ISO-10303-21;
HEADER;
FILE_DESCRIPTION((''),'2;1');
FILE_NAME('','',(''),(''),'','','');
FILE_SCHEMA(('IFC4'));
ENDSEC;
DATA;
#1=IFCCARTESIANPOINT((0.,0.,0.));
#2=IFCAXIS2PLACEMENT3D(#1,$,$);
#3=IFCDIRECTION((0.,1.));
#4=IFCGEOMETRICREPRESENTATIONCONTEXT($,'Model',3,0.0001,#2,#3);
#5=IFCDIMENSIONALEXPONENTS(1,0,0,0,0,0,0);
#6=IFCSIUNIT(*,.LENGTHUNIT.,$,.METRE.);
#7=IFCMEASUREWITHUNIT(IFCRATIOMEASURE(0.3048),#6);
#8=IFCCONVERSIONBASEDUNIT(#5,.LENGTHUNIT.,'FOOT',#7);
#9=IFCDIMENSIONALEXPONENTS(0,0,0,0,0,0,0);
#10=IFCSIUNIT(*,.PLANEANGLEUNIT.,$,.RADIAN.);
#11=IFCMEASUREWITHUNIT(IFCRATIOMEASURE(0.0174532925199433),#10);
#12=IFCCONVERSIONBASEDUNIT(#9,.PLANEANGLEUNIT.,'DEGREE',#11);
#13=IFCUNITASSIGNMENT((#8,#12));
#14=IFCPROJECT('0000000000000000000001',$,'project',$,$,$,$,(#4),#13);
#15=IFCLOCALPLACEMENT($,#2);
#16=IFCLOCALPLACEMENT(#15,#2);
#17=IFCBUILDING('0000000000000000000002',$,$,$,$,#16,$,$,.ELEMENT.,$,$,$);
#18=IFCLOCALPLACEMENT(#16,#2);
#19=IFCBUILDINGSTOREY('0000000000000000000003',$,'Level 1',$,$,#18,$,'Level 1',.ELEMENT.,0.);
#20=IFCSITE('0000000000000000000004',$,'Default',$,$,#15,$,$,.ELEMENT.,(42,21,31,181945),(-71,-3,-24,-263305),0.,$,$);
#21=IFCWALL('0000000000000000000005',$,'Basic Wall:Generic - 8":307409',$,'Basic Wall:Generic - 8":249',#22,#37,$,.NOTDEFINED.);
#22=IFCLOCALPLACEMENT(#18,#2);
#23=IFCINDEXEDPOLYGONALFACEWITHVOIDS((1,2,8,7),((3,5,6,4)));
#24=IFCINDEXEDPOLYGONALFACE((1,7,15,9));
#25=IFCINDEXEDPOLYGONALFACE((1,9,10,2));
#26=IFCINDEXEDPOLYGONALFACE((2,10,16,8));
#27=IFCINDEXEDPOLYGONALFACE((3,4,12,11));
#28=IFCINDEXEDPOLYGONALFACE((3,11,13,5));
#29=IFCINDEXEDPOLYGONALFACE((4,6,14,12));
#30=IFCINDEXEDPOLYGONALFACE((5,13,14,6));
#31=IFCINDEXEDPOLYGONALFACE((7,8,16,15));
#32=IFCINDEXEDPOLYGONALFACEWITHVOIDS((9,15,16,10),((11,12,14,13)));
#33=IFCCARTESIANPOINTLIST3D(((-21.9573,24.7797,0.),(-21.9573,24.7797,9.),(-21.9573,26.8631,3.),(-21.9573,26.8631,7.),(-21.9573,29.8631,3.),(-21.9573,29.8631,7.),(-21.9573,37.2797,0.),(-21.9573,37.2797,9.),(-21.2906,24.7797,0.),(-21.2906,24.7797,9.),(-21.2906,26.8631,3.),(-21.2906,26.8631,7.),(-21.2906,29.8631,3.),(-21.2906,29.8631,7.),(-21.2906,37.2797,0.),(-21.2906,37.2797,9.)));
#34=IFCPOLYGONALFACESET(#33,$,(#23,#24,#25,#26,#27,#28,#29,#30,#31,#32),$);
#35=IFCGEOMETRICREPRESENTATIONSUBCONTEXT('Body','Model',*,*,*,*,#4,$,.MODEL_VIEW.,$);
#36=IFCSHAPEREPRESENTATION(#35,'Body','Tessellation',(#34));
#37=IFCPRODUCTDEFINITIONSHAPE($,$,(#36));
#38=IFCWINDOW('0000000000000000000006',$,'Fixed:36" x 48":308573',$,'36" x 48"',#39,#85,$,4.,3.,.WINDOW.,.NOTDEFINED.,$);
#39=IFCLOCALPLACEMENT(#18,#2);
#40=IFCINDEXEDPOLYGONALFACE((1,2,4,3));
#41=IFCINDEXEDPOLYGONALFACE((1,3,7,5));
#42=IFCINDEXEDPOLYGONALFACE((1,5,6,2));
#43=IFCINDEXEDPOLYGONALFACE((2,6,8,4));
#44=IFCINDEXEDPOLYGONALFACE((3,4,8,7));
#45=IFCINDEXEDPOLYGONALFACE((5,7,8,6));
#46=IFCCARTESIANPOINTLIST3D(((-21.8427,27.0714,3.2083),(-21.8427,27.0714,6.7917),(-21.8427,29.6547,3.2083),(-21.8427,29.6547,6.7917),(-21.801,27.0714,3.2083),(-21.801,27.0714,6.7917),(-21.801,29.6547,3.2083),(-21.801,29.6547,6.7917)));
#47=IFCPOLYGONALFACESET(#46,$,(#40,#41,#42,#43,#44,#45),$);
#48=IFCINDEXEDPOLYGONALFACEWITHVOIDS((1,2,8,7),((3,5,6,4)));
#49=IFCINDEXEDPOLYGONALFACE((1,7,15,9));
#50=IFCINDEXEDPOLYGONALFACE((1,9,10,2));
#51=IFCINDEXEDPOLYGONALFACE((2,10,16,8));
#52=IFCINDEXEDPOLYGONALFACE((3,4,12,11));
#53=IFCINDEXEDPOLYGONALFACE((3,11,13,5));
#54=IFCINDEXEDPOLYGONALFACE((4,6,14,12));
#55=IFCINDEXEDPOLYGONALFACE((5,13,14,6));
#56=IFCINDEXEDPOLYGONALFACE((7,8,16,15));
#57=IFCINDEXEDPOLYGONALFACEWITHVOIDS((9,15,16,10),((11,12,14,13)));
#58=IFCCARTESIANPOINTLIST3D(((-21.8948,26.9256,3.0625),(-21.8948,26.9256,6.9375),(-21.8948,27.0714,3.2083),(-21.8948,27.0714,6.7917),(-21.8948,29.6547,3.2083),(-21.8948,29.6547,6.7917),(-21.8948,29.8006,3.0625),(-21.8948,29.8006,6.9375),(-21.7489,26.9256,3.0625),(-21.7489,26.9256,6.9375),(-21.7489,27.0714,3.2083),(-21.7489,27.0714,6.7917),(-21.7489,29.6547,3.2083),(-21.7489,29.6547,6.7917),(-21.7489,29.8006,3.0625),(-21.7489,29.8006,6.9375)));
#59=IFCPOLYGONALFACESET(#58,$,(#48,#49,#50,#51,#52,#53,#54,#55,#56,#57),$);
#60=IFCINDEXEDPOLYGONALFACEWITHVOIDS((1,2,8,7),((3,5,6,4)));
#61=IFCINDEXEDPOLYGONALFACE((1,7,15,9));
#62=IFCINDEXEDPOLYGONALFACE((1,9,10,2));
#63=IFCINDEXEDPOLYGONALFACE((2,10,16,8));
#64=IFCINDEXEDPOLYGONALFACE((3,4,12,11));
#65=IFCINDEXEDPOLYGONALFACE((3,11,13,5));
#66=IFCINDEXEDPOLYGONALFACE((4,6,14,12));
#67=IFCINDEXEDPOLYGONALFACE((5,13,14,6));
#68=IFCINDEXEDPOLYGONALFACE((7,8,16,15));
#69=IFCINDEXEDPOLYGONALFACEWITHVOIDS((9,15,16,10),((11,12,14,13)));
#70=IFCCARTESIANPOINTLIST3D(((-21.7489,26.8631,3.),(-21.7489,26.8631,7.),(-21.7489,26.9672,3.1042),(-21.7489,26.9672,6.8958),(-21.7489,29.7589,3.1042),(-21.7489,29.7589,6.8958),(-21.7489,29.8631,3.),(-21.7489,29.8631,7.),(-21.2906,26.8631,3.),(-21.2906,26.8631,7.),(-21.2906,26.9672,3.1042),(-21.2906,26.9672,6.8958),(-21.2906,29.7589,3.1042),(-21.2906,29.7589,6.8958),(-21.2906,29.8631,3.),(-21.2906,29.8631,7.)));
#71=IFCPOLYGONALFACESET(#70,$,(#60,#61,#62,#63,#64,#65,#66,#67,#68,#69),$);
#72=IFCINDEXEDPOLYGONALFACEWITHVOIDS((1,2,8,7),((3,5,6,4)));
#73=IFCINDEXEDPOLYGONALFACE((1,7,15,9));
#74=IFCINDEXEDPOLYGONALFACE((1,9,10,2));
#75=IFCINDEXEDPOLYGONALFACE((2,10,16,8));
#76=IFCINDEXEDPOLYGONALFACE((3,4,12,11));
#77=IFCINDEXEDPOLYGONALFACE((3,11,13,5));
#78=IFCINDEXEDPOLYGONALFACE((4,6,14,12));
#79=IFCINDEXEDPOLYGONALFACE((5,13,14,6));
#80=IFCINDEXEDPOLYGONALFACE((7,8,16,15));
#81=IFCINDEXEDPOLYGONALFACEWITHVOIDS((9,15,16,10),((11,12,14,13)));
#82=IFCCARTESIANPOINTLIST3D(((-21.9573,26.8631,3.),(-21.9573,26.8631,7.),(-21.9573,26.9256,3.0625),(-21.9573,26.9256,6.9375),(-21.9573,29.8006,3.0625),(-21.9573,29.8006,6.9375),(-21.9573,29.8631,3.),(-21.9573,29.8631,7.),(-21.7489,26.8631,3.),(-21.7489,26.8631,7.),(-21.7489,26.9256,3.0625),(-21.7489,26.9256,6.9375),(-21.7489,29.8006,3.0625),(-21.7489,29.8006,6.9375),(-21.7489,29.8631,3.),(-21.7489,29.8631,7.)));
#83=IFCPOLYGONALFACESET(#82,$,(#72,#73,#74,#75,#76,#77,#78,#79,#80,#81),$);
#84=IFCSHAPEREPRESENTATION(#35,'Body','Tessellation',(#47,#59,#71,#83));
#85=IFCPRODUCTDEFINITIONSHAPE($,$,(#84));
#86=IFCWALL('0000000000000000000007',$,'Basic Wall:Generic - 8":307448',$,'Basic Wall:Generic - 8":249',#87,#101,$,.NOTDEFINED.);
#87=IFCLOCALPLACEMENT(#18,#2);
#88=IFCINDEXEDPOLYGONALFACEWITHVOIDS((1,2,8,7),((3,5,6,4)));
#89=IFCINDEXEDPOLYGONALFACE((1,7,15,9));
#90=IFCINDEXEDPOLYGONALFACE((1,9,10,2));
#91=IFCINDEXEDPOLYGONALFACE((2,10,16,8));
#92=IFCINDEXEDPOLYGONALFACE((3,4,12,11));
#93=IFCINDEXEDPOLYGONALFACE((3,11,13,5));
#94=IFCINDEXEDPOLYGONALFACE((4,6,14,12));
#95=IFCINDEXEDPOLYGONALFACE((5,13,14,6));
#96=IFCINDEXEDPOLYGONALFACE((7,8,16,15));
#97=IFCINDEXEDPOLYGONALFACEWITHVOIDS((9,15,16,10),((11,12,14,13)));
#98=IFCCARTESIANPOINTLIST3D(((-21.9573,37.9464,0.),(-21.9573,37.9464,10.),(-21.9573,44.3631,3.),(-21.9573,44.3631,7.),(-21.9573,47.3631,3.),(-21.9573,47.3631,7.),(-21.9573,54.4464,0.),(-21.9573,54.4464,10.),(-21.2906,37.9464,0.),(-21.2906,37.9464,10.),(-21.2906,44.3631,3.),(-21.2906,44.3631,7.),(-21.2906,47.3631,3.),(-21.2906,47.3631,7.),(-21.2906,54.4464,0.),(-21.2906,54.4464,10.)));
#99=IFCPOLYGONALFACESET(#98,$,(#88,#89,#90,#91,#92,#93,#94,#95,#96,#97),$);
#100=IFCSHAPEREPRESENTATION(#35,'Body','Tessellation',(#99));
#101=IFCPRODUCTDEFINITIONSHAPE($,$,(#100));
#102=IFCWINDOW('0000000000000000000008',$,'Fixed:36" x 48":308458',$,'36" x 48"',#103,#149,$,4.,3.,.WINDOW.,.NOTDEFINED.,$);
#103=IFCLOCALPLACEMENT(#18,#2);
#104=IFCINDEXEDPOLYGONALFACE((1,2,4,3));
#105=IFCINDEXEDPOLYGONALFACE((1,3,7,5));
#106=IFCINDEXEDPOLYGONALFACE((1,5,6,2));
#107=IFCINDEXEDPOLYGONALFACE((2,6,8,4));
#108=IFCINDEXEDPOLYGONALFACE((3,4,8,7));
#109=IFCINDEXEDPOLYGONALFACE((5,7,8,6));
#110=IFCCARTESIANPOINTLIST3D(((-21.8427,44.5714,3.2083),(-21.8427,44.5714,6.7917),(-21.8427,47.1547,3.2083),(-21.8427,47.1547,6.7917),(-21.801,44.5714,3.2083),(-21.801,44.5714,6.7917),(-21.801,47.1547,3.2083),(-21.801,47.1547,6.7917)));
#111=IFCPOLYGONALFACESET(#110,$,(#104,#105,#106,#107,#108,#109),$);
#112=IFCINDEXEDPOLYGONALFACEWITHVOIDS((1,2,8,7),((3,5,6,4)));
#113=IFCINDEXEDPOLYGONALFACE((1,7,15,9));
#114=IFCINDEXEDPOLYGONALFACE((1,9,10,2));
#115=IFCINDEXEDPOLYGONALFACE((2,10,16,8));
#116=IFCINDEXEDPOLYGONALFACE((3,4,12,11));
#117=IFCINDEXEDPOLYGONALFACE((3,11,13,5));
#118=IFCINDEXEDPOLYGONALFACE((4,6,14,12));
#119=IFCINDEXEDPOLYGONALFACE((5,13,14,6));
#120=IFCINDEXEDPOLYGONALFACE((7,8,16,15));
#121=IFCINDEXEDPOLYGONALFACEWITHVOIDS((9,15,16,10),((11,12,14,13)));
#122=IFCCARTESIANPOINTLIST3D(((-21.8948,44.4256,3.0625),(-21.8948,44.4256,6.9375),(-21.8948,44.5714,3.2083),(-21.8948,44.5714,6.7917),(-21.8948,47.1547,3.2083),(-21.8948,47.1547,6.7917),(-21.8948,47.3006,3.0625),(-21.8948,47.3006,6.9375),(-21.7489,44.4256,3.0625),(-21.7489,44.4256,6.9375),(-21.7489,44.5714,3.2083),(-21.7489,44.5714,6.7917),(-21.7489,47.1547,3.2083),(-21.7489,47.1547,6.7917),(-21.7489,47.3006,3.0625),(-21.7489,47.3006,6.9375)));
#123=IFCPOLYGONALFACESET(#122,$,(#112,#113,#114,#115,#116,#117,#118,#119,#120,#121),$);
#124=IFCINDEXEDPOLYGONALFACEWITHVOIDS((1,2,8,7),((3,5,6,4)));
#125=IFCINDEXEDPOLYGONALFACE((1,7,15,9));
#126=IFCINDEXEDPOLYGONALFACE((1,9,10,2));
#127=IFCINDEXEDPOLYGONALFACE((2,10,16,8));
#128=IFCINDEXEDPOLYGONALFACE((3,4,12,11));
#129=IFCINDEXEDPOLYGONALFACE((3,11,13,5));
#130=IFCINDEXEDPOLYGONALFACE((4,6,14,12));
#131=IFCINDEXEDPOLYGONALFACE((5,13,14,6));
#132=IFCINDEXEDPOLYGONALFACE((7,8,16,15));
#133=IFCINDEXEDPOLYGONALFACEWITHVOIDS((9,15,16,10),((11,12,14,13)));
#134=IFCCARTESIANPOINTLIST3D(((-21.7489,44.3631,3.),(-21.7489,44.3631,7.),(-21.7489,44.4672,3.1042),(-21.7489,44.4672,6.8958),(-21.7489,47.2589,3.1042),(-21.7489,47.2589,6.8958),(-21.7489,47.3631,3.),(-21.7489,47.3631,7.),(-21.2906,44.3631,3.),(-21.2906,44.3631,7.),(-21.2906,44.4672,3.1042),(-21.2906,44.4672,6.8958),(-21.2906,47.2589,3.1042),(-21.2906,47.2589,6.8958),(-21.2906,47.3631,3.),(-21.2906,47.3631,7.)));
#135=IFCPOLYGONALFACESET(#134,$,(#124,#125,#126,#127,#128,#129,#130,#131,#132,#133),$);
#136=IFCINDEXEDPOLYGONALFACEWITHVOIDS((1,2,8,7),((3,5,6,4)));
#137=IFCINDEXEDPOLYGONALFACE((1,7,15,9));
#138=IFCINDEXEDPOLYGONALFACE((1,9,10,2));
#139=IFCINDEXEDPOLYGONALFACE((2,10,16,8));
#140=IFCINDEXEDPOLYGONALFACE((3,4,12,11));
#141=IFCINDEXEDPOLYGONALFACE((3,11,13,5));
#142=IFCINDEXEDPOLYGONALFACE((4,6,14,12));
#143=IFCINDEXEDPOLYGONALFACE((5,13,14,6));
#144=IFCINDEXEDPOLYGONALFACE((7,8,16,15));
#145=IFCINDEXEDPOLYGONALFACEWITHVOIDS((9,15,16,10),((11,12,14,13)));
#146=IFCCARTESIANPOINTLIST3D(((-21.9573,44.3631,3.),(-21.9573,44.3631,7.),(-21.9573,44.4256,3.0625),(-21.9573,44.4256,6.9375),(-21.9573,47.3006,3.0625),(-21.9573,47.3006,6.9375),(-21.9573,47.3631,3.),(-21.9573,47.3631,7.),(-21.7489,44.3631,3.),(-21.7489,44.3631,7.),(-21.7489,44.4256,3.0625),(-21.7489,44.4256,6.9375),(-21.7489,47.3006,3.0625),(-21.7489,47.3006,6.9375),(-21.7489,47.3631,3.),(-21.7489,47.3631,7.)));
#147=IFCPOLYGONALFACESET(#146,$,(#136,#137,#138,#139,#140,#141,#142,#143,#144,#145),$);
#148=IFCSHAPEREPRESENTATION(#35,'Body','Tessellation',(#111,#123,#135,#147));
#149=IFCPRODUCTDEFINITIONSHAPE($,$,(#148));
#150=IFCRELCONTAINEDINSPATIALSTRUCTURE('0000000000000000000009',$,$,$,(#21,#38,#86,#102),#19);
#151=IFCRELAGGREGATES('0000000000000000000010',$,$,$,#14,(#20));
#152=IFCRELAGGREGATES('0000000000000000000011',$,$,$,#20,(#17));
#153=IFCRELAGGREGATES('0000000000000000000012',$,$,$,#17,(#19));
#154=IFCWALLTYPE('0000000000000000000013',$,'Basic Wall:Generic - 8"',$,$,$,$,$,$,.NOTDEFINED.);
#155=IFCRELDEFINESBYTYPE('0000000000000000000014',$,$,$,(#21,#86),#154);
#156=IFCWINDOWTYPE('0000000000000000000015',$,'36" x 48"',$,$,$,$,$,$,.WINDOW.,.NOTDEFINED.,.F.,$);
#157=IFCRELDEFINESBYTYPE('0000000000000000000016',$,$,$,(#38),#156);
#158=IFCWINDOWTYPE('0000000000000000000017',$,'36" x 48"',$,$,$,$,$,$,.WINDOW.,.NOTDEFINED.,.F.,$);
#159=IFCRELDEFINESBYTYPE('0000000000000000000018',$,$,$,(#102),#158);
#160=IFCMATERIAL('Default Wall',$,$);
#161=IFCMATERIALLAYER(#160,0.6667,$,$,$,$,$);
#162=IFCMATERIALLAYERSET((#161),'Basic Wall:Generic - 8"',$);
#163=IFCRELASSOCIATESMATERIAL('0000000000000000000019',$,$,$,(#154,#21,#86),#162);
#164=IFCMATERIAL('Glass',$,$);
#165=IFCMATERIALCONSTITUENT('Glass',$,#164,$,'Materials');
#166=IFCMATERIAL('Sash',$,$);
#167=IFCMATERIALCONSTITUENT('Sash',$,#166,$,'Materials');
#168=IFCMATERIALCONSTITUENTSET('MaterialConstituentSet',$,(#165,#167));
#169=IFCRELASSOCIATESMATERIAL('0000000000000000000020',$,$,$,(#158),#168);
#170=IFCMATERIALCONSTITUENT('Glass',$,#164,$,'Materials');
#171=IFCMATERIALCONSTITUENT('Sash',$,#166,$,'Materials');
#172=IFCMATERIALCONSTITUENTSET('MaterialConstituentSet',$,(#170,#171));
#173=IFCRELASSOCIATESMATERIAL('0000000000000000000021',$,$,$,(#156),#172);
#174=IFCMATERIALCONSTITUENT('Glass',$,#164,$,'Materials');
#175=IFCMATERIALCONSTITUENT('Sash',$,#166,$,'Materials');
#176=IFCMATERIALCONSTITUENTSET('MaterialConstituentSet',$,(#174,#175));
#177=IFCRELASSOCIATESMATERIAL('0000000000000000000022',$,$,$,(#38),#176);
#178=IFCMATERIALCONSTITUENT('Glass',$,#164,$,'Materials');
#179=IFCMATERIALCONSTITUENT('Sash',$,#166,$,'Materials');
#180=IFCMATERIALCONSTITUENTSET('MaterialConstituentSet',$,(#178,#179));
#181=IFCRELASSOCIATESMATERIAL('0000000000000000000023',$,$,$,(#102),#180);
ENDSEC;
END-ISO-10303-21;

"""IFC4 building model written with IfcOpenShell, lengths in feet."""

from ifc_helpers import new_model, entity, si_unit, converted_unit, direction, frame, frame_2d, origin, place, context, subcontext, project, spatial, polyline, rectangle, outline, extrude, clip, bounded_halfspace, source, transform, mapped, material, layer, layer_set, layer_usage, constituent, constituent_set, type_object, type_shapes, element, fill, save


model = new_model("IFC4")

# Units and contexts
model_context = context("Model", 3, precision=0.0001, world=origin(), true_north=direction((0.0, 1.0)))
body_context = subcontext(model_context, "Body", "Model", "MODEL_VIEW")
ifc_project = project(units=[converted_unit("LENGTHUNIT", "FOOT", entity("IfcRatioMeasure", 0.3048), si_unit("LENGTHUNIT", "METRE"), dimensions=[1, 0, 0, 0, 0, 0, 0]), converted_unit("PLANEANGLEUNIT", "DEGREE", entity("IfcRatioMeasure", 0.0174532925199433), si_unit("PLANEANGLEUNIT", "RADIAN"), dimensions=[0, 0, 0, 0, 0, 0, 0])], contexts=[model_context])

# Site, building, storey
site_placement = place(None, origin())
site = spatial("IfcSite", under=ifc_project, at=site_placement, Name="Default", CompositionType="ELEMENT", RefLatitude=(42, 21, 31, 181945), RefLongitude=(-71, -3, -24, -263305), RefElevation=0.0)
building_placement = place(site_placement, origin())
building = spatial("IfcBuilding", under=site, at=building_placement, CompositionType="ELEMENT")
storey_placement = place(building_placement, origin())
storey = spatial("IfcBuildingStorey", under=building, at=storey_placement, Name="Level 1", LongName="Level 1", CompositionType="ELEMENT", Elevation=0.0)

# Shared definitions
ifc_material_1 = material(Name="Default Wall")
ifc_layer = layer(ifc_material_1, 0.6667)
ifc_layer_set = layer_set([ifc_layer], Name="Basic Wall:Generic - 8\"")
wall_type = type_object("IfcWallType", Name="Basic Wall:Generic - 8\"", PredefinedType="NOTDEFINED", material=ifc_layer_set)
ifc_material_2 = material(Name="Glass")
ifc_material_3 = material(Name="Sash")
ifc_constituent_1 = constituent(ifc_material_2, Name="Glass", Category="Materials")
ifc_constituent_2 = constituent(ifc_material_3, Name="Sash", Category="Materials")
ifc_constituent_set_1 = constituent_set(constituents=[ifc_constituent_1, ifc_constituent_2], Name="MaterialConstituentSet")
window_type_1 = type_object("IfcWindowType", Name="36\" x 48\"", ParameterTakesPrecedence=False, PartitioningType="NOTDEFINED", PredefinedType="WINDOW", material=ifc_constituent_set_1)
shared_shape_1 = source(origin(), body_context, "Body", "SweptSolid", [
    extrude(rectangle(XDim=0.0417, YDim=2.5833, at=frame_2d((0.0, 0.0), x_axis=(1.0, 0.0))), frame((1.5, 0.5312, 0.2083), z_axis=(0.0, 0.0, 1.0), x_axis=(0.0, 1.0, 0.0)), (0.0, 0.0, 1.0), 3.5833),
    extrude(outline(polyline([(-1.4375, -1.9375), (1.4375, -1.9375), (1.4375, 1.9375), (-1.4375, 1.9375), (-1.4375, -1.9375)]), holes=[polyline([(-1.2917, -1.7917), (-1.2917, 1.7917), (1.2917, 1.7917), (1.2917, -1.7917), (-1.2917, -1.7917)])]), frame((1.5, 0.4583, 2.0), z_axis=(0.0, 1.0, 0.0), x_axis=(1.0, 0.0, 0.0)), (0.0, 0.0, 1.0), 0.1458),
    extrude(outline(polyline([(-1.5, -2.0), (1.5, -2.0), (1.5, 2.0), (-1.5, 2.0), (-1.5, -2.0)]), holes=[polyline([(-1.3958, -1.8958), (-1.3958, 1.8958), (1.3958, 1.8958), (1.3958, -1.8958), (-1.3958, -1.8958)])]), frame((1.5, 0.0, 2.0), z_axis=(0.0, 1.0, 0.0), x_axis=(1.0, 0.0, 0.0)), (0.0, 0.0, 1.0), 0.4583),
    extrude(outline(polyline([(-2.0, -1.5), (2.0, -1.5), (2.0, 1.5), (-2.0, 1.5), (-2.0, -1.5)]), holes=[polyline([(-1.9375, -1.4375), (-1.9375, 1.4375), (1.9375, 1.4375), (1.9375, -1.4375), (-1.9375, -1.4375)])]), frame((1.5, 0.4583, 2.0), z_axis=(0.0, 1.0, 0.0), x_axis=(0.0, 0.0, -1.0)), (0.0, 0.0, 1.0), 0.2083),
])
type_shapes(window_type_1, [shared_shape_1])

# Walls, openings, windows
ifc_layer_usage_1 = layer_usage(ifc_layer_set, "AXIS2", "NEGATIVE", 0.3333)
wall_1_placement = place(storey_placement, frame((-21.6239, 24.7797, 0.0), z_axis=(0.0, 0.0, 1.0), x_axis=(0.0, 1.0, 0.0)))
wall_1 = element("IfcWall", 1, at=wall_1_placement, inside=storey, type_object=wall_type, material=ifc_layer_usage_1, Name="Basic Wall:Generic - 8\":307409", ObjectType="Basic Wall:Generic - 8\":249", PredefinedType="NOTDEFINED", context=body_context, shape_type="Clipping", body=[
    clip(extrude(rectangle(XDim=12.5, YDim=0.6667, at=frame_2d((6.25, 0.0), x_axis=(-1.0, 0.0))), origin(), (0.0, 0.0, 1.0), 9.0), bounded_halfspace(frame((0.0, -0.3333, 9.0), z_axis=(0.0, 0.0, -1.0), x_axis=(0.0, -1.0, 0.0)), True, frame((0.0, -0.3333, 9.0)), polyline([(0.0, 0.0), (12.5, 0.0), (12.5, 0.6667), (0.6667, 0.6667), (0.0, 0.6667), (0.0, 0.0)]))),
])
opening_1_placement = place(wall_1_placement, frame((2.0833, -0.3333, 3.0)))
opening_1 = element("IfcOpeningElement", 2, at=opening_1_placement, cuts=wall_1, ObjectType="Opening", PredefinedType="OPENING", context=body_context, shape_type="SweptSolid", body=[
    extrude(rectangle(XDim=4.0, YDim=3.0, at=frame_2d((2.0, 1.5), x_axis=(-1.0, 0.0))), frame((0.0, 0.0, 0.0), z_axis=(0.0, 1.0, 0.0), x_axis=(0.0, 0.0, 1.0)), (0.0, 0.0, 1.0), 0.6667),
])
ifc_constituent_3 = constituent(ifc_material_2, Name="Glass", Category="Materials")
ifc_constituent_4 = constituent(ifc_material_3, Name="Sash", Category="Materials")
ifc_constituent_set_2 = constituent_set(constituents=[ifc_constituent_3, ifc_constituent_4], Name="MaterialConstituentSet")
ifc_constituent_5 = constituent(ifc_material_2, Name="Glass", Category="Materials")
ifc_constituent_6 = constituent(ifc_material_3, Name="Sash", Category="Materials")
ifc_constituent_set_3 = constituent_set(constituents=[ifc_constituent_5, ifc_constituent_6], Name="MaterialConstituentSet")
window_type_2 = type_object("IfcWindowType", Name="36\" x 48\"", ParameterTakesPrecedence=False, PartitioningType="NOTDEFINED", PredefinedType="WINDOW", material=ifc_constituent_set_3)
shared_shape_2 = source(origin(), body_context, "Body", "SweptSolid", [
    extrude(rectangle(XDim=2.5833, YDim=0.0417, at=frame_2d((0.0, 0.0), x_axis=(1.0, 0.0))), frame((1.75, 0.5312, 0.2083)), (0.0, 0.0, 1.0), 3.5833),
    extrude(outline(polyline([(-1.4375, -1.9375), (1.4375, -1.9375), (1.4375, 1.9375), (-1.4375, 1.9375), (-1.4375, -1.9375)]), holes=[polyline([(-1.2917, -1.7917), (-1.2917, 1.7917), (1.2917, 1.7917), (1.2917, -1.7917), (-1.2917, -1.7917)])]), frame((1.75, 0.6042, 2.0), z_axis=(0.0, -1.0, 0.0), x_axis=(-1.0, 0.0, 0.0)), (0.0, 0.0, 1.0), 0.1458),
    extrude(outline(polyline([(-1.5, -2.0), (1.5, -2.0), (1.5, 2.0), (-1.5, 2.0), (-1.5, -2.0)]), holes=[polyline([(-1.3958, -1.8958), (-1.3958, 1.8958), (1.3958, 1.8958), (1.3958, -1.8958), (-1.3958, -1.8958)])]), frame((1.75, 0.4583, 2.0), z_axis=(0.0, -1.0, 0.0), x_axis=(-1.0, 0.0, 0.0)), (0.0, 0.0, 1.0), 0.4583),
    extrude(outline(polyline([(-2.0, -1.5), (2.0, -1.5), (2.0, 1.5), (-2.0, 1.5), (-2.0, -1.5)]), holes=[polyline([(-1.9375, -1.4375), (-1.9375, 1.4375), (1.9375, 1.4375), (1.9375, -1.4375), (-1.9375, -1.4375)])]), frame((1.75, 0.6667, 2.0), z_axis=(0.0, -1.0, 0.0), x_axis=(0.0, 0.0, -1.0)), (0.0, 0.0, 1.0), 0.2083),
])
type_shapes(window_type_2, [shared_shape_2])
window_1_placement = place(opening_1_placement, frame((-0.25, 0.0, 0.0)))
window_1 = element("IfcWindow", 3, at=window_1_placement, inside=storey, type_object=window_type_2, material=ifc_constituent_set_2, Name="Fixed:36\" x 48\":308573", ObjectType="36\" x 48\"", OverallHeight=4.0, OverallWidth=3.0, PartitioningType="NOTDEFINED", PredefinedType="WINDOW", context=body_context, shape_type="MappedRepresentation", body=[
    mapped(shared_shape_2, transform((0.0, 0.0, 0.0), scale=1.0)),
])
fill(opening_1, window_1)
ifc_layer_usage_2 = layer_usage(ifc_layer_set, "AXIS2", "NEGATIVE", 0.3333)
wall_2_placement = place(storey_placement, frame((-21.6239, 54.4464, 0.0), z_axis=(0.0, 0.0, 1.0), x_axis=(0.0, -1.0, 0.0)))
wall_2 = element("IfcWall", 4, at=wall_2_placement, inside=storey, type_object=wall_type, material=ifc_layer_usage_2, Name="Basic Wall:Generic - 8\":307448", ObjectType="Basic Wall:Generic - 8\":249", PredefinedType="NOTDEFINED", context=body_context, shape_type="SweptSolid", body=[
    extrude(rectangle(XDim=16.5, YDim=0.6667, at=frame_2d((8.25, 0.0), x_axis=(-1.0, 0.0))), origin(), (0.0, 0.0, 1.0), 10.0),
])
opening_2_placement = place(wall_2_placement, frame((10.0833, 0.3333, 3.0)))
opening_2 = element("IfcOpeningElement", 5, at=opening_2_placement, cuts=wall_2, ObjectType="Opening", PredefinedType="OPENING", context=body_context, shape_type="SweptSolid", body=[
    extrude(rectangle(XDim=4.0, YDim=3.0, at=frame_2d((2.0, 1.5), x_axis=(-1.0, 0.0))), frame((0.0, 0.0, 0.0), z_axis=(0.0, -1.0, 0.0), x_axis=(0.0, 0.0, 1.0)), (0.0, 0.0, 1.0), 0.6667),
])
ifc_constituent_7 = constituent(ifc_material_2, Name="Glass", Category="Materials")
ifc_constituent_8 = constituent(ifc_material_3, Name="Sash", Category="Materials")
ifc_constituent_set_4 = constituent_set(constituents=[ifc_constituent_7, ifc_constituent_8], Name="MaterialConstituentSet")
window_2_placement = place(opening_2_placement, frame((0.0, 0.0, 0.0), z_axis=(0.0, 0.0, 1.0), x_axis=(-1.0, 0.0, 0.0)))
window_2 = element("IfcWindow", 6, at=window_2_placement, inside=storey, type_object=window_type_1, material=ifc_constituent_set_4, Name="Fixed:36\" x 48\":308458", ObjectType="36\" x 48\"", OverallHeight=4.0, OverallWidth=3.0, PartitioningType="NOTDEFINED", PredefinedType="WINDOW", context=body_context, shape_type="MappedRepresentation", body=[
    mapped(shared_shape_1, transform((0.0, 0.0, 0.0), scale=1.0)),
])
fill(opening_2, window_2)

save(model, "model.ifc")
